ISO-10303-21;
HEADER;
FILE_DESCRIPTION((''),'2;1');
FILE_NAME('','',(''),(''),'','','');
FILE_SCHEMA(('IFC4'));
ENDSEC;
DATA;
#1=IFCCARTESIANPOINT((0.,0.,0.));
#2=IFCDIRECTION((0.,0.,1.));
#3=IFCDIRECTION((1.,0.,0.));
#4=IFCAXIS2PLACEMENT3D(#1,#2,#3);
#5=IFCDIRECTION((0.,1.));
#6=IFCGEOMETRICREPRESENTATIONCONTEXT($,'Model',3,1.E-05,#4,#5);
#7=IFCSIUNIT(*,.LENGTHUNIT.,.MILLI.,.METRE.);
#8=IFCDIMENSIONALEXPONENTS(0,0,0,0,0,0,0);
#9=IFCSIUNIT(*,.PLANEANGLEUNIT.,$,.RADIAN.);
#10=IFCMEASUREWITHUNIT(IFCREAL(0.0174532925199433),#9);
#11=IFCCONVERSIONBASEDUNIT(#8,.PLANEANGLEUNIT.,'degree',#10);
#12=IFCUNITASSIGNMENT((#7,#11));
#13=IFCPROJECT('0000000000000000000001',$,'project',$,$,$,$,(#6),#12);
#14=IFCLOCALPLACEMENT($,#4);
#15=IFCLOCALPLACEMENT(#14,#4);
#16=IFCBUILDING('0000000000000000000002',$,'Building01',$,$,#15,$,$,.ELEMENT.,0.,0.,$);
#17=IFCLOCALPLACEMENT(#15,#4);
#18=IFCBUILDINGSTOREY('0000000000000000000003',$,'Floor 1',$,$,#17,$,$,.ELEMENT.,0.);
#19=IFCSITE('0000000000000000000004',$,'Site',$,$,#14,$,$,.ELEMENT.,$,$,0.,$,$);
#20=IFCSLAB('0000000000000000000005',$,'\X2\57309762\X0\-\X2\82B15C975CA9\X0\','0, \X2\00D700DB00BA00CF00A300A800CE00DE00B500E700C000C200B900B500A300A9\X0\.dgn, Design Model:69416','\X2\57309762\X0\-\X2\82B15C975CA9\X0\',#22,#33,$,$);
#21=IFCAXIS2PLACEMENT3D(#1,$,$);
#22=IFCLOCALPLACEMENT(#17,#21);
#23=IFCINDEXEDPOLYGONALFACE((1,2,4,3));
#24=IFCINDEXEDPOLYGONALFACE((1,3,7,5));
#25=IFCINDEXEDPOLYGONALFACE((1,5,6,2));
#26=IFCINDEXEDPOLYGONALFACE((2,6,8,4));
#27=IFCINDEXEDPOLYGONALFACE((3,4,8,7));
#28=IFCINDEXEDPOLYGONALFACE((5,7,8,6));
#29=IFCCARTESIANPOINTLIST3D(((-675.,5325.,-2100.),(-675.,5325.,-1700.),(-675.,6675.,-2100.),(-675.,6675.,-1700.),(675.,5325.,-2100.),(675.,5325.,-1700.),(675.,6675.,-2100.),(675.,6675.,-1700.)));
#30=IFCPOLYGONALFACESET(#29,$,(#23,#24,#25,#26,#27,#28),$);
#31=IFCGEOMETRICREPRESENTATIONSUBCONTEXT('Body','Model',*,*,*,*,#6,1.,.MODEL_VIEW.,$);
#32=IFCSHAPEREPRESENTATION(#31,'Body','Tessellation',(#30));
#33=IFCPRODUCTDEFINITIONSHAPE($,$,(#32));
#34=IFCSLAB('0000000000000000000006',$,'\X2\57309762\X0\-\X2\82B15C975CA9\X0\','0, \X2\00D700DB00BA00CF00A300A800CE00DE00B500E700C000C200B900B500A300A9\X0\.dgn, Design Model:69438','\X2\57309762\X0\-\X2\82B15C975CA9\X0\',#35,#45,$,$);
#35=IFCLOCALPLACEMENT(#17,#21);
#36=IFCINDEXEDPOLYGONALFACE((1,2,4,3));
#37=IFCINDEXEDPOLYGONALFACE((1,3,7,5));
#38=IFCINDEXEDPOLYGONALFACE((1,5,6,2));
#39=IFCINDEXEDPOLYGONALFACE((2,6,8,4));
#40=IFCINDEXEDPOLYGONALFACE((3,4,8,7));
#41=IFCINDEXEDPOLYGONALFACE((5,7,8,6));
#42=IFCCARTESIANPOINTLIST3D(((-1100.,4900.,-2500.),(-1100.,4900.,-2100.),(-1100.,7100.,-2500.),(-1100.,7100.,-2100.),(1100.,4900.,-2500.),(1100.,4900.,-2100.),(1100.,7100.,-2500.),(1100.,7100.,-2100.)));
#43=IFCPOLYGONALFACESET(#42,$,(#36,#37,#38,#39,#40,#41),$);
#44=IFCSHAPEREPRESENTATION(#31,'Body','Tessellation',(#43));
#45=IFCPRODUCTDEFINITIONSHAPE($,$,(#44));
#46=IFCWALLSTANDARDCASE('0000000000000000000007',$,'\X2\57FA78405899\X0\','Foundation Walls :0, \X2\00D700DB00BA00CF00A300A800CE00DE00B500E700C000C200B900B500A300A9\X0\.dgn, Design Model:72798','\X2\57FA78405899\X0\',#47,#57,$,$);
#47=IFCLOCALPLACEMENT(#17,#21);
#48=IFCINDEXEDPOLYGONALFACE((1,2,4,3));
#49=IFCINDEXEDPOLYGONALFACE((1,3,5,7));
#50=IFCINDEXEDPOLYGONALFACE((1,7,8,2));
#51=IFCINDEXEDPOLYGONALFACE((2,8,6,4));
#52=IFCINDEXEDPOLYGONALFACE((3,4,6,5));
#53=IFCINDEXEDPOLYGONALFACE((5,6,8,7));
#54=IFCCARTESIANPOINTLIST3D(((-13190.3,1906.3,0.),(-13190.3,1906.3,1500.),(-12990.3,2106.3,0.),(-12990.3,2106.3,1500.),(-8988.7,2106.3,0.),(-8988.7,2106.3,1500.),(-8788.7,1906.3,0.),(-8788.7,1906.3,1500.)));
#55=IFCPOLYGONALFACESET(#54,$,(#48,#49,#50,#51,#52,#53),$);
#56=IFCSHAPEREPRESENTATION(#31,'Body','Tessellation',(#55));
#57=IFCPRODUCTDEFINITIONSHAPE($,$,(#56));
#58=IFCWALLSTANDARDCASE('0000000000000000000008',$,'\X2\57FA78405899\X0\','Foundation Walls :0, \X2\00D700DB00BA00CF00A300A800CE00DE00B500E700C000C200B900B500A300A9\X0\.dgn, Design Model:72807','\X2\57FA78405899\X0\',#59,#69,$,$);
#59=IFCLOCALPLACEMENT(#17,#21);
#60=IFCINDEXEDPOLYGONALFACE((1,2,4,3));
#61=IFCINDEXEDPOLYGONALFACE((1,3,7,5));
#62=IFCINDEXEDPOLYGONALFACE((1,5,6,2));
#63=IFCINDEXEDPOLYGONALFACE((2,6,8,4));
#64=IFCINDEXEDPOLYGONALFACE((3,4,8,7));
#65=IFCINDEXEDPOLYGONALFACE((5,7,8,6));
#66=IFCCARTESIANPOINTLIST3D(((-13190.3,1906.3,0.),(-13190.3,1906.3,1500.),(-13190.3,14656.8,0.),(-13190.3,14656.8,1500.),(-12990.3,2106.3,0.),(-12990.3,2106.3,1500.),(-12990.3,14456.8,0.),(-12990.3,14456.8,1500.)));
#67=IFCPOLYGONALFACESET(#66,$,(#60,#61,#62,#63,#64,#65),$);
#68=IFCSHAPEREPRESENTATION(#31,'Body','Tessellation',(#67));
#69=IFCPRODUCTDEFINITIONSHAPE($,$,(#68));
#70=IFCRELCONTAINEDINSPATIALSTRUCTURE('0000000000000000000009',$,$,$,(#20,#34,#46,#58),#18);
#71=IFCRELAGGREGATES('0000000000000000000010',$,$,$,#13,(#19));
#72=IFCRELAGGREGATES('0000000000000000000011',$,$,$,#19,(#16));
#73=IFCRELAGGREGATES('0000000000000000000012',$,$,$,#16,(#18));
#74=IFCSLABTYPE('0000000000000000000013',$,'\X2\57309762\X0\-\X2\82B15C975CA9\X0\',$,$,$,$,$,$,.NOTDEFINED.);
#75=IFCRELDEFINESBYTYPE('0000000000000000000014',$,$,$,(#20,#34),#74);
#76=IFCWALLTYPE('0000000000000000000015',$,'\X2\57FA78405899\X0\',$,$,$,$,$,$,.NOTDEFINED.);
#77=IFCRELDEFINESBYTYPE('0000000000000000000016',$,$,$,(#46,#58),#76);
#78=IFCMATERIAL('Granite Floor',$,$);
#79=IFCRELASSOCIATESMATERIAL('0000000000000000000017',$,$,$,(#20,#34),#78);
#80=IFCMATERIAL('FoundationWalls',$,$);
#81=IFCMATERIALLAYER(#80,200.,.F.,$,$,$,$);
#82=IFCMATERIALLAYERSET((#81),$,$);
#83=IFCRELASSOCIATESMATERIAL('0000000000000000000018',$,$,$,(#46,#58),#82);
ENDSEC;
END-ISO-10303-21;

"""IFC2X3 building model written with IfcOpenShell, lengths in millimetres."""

from ifc_helpers import new_model, entity, si_unit, converted_unit, direction, frame, frame_2d, origin_with_axes, place, context, subcontext, project, spatial, polyline, rectangle, outline, extrude, material, layer, layer_set, layer_usage, type_object, element, save


model = new_model("IFC2X3")

# Units and contexts
model_context = context("Model", 3, precision=1e-05, world=origin_with_axes(), true_north=direction((0.0, 1.0)))
body_context = subcontext(model_context, "Body", "Model", "MODEL_VIEW", scale=1.0)
ifc_project = project(units=[si_unit("LENGTHUNIT", "METRE", prefix="MILLI"), converted_unit("PLANEANGLEUNIT", "degree", entity("IfcReal", 0.0174532925199433), si_unit("PLANEANGLEUNIT", "RADIAN"), dimensions=[0, 0, 0, 0, 0, 0, 0])], contexts=[model_context])

# Site, building, storey
site_placement = place(None, origin_with_axes())
site = spatial("IfcSite", under=ifc_project, at=site_placement, Name="Site", CompositionType="ELEMENT", RefElevation=0.0)
building_placement = place(site_placement, origin_with_axes())
building = spatial("IfcBuilding", under=site, at=building_placement, Name="Building01", CompositionType="ELEMENT", ElevationOfRefHeight=0.0, ElevationOfTerrain=0.0)
storey_placement = place(building_placement, origin_with_axes())
storey = spatial("IfcBuildingStorey", under=building, at=storey_placement, Name="Floor 1", CompositionType="ELEMENT", Elevation=0.0)

# Slabs
ifc_material_1 = material(Name="Granite Floor")
slab_type = type_object("IfcSlabType", Name="地面-花岗岩", PredefinedType="NOTDEFINED")
slab_1_placement = place(storey_placement, frame((-675.0, 5325.0, -2100.0), z_axis=(0.0, 0.0, 1.0), x_axis=(1.0, 0.0, 0.0)))
element("IfcSlab", 1, at=slab_1_placement, inside=storey, type_object=slab_type, material=ifc_material_1, Name="地面-花岗岩", Description="0, ×ÛºÏ£¨ÎÞµçÀÂ¹µ£©.dgn, Design Model:69416", ObjectType="地面-花岗岩", context=body_context, shape_type="SweptSolid", body=[
    extrude(rectangle(XDim=1350.0, YDim=1350.0, at=frame_2d((675.0, 675.0), x_axis=(1.0, 0.0))), origin_with_axes(), (0.0, 0.0, 1.0), 400.0),
])
slab_2_placement = place(storey_placement, frame((-1100.0, 4900.0, -2500.0), z_axis=(0.0, 0.0, 1.0), x_axis=(1.0, 0.0, 0.0)))
element("IfcSlab", 2, at=slab_2_placement, inside=storey, type_object=slab_type, material=ifc_material_1, Name="地面-花岗岩", Description="0, ×ÛºÏ£¨ÎÞµçÀÂ¹µ£©.dgn, Design Model:69438", ObjectType="地面-花岗岩", context=body_context, shape_type="SweptSolid", body=[
    extrude(rectangle(XDim=2200.0, YDim=2200.0, at=frame_2d((1100.0, 1100.0), x_axis=(1.0, 0.0))), origin_with_axes(), (0.0, 0.0, 1.0), 400.0),
])

# Walls
ifc_material_2 = material(Name="FoundationWalls")
ifc_layer = layer(ifc_material_2, 200.0, ventilated=False)
ifc_layer_set = layer_set([ifc_layer])
ifc_layer_usage = layer_usage(ifc_layer_set, "AXIS2", "POSITIVE", 0.0)
wall_type = type_object("IfcWallType", Name="基础墙", PredefinedType="NOTDEFINED")
wall_1_placement = place(storey_placement, frame((-8988.7, 2106.3, 0.0), z_axis=(0.0, 0.0, 1.0), x_axis=(-1.0, 0.0, 0.0)))
element("IfcWallStandardCase", 3, at=wall_1_placement, inside=storey, type_object=wall_type, material=ifc_layer_usage, Name="基础墙", Description="Foundation Walls :0, ×ÛºÏ£¨ÎÞµçÀÂ¹µ£©.dgn, Design Model:72798", ObjectType="基础墙", context=body_context, shape_type="SweptSolid", body=[
    extrude(outline(polyline([(4201.6, 200.0), (-200.0, 200.0), (0.0, 0.0), (4001.6, 0.0), (4201.6, 200.0)])), origin_with_axes(), (0.0, 0.0, 1.0), 1500.0),
])
wall_2_placement = place(storey_placement, frame((-12990.3, 2106.3, 0.0), z_axis=(0.0, 0.0, 1.0), x_axis=(0.0, 1.0, 0.0)))
element("IfcWallStandardCase", 4, at=wall_2_placement, inside=storey, type_object=wall_type, material=ifc_layer_usage, Name="基础墙", Description="Foundation Walls :0, ×ÛºÏ£¨ÎÞµçÀÂ¹µ£©.dgn, Design Model:72807", ObjectType="基础墙", context=body_context, shape_type="SweptSolid", body=[
    extrude(outline(polyline([(12550.5, 200.0), (-200.0, 200.0), (0.0, 0.0), (12350.5, 0.0), (12550.5, 200.0)])), origin_with_axes(), (0.0, 0.0, 1.0), 1500.0),
])

save(model, "model.ifc")
